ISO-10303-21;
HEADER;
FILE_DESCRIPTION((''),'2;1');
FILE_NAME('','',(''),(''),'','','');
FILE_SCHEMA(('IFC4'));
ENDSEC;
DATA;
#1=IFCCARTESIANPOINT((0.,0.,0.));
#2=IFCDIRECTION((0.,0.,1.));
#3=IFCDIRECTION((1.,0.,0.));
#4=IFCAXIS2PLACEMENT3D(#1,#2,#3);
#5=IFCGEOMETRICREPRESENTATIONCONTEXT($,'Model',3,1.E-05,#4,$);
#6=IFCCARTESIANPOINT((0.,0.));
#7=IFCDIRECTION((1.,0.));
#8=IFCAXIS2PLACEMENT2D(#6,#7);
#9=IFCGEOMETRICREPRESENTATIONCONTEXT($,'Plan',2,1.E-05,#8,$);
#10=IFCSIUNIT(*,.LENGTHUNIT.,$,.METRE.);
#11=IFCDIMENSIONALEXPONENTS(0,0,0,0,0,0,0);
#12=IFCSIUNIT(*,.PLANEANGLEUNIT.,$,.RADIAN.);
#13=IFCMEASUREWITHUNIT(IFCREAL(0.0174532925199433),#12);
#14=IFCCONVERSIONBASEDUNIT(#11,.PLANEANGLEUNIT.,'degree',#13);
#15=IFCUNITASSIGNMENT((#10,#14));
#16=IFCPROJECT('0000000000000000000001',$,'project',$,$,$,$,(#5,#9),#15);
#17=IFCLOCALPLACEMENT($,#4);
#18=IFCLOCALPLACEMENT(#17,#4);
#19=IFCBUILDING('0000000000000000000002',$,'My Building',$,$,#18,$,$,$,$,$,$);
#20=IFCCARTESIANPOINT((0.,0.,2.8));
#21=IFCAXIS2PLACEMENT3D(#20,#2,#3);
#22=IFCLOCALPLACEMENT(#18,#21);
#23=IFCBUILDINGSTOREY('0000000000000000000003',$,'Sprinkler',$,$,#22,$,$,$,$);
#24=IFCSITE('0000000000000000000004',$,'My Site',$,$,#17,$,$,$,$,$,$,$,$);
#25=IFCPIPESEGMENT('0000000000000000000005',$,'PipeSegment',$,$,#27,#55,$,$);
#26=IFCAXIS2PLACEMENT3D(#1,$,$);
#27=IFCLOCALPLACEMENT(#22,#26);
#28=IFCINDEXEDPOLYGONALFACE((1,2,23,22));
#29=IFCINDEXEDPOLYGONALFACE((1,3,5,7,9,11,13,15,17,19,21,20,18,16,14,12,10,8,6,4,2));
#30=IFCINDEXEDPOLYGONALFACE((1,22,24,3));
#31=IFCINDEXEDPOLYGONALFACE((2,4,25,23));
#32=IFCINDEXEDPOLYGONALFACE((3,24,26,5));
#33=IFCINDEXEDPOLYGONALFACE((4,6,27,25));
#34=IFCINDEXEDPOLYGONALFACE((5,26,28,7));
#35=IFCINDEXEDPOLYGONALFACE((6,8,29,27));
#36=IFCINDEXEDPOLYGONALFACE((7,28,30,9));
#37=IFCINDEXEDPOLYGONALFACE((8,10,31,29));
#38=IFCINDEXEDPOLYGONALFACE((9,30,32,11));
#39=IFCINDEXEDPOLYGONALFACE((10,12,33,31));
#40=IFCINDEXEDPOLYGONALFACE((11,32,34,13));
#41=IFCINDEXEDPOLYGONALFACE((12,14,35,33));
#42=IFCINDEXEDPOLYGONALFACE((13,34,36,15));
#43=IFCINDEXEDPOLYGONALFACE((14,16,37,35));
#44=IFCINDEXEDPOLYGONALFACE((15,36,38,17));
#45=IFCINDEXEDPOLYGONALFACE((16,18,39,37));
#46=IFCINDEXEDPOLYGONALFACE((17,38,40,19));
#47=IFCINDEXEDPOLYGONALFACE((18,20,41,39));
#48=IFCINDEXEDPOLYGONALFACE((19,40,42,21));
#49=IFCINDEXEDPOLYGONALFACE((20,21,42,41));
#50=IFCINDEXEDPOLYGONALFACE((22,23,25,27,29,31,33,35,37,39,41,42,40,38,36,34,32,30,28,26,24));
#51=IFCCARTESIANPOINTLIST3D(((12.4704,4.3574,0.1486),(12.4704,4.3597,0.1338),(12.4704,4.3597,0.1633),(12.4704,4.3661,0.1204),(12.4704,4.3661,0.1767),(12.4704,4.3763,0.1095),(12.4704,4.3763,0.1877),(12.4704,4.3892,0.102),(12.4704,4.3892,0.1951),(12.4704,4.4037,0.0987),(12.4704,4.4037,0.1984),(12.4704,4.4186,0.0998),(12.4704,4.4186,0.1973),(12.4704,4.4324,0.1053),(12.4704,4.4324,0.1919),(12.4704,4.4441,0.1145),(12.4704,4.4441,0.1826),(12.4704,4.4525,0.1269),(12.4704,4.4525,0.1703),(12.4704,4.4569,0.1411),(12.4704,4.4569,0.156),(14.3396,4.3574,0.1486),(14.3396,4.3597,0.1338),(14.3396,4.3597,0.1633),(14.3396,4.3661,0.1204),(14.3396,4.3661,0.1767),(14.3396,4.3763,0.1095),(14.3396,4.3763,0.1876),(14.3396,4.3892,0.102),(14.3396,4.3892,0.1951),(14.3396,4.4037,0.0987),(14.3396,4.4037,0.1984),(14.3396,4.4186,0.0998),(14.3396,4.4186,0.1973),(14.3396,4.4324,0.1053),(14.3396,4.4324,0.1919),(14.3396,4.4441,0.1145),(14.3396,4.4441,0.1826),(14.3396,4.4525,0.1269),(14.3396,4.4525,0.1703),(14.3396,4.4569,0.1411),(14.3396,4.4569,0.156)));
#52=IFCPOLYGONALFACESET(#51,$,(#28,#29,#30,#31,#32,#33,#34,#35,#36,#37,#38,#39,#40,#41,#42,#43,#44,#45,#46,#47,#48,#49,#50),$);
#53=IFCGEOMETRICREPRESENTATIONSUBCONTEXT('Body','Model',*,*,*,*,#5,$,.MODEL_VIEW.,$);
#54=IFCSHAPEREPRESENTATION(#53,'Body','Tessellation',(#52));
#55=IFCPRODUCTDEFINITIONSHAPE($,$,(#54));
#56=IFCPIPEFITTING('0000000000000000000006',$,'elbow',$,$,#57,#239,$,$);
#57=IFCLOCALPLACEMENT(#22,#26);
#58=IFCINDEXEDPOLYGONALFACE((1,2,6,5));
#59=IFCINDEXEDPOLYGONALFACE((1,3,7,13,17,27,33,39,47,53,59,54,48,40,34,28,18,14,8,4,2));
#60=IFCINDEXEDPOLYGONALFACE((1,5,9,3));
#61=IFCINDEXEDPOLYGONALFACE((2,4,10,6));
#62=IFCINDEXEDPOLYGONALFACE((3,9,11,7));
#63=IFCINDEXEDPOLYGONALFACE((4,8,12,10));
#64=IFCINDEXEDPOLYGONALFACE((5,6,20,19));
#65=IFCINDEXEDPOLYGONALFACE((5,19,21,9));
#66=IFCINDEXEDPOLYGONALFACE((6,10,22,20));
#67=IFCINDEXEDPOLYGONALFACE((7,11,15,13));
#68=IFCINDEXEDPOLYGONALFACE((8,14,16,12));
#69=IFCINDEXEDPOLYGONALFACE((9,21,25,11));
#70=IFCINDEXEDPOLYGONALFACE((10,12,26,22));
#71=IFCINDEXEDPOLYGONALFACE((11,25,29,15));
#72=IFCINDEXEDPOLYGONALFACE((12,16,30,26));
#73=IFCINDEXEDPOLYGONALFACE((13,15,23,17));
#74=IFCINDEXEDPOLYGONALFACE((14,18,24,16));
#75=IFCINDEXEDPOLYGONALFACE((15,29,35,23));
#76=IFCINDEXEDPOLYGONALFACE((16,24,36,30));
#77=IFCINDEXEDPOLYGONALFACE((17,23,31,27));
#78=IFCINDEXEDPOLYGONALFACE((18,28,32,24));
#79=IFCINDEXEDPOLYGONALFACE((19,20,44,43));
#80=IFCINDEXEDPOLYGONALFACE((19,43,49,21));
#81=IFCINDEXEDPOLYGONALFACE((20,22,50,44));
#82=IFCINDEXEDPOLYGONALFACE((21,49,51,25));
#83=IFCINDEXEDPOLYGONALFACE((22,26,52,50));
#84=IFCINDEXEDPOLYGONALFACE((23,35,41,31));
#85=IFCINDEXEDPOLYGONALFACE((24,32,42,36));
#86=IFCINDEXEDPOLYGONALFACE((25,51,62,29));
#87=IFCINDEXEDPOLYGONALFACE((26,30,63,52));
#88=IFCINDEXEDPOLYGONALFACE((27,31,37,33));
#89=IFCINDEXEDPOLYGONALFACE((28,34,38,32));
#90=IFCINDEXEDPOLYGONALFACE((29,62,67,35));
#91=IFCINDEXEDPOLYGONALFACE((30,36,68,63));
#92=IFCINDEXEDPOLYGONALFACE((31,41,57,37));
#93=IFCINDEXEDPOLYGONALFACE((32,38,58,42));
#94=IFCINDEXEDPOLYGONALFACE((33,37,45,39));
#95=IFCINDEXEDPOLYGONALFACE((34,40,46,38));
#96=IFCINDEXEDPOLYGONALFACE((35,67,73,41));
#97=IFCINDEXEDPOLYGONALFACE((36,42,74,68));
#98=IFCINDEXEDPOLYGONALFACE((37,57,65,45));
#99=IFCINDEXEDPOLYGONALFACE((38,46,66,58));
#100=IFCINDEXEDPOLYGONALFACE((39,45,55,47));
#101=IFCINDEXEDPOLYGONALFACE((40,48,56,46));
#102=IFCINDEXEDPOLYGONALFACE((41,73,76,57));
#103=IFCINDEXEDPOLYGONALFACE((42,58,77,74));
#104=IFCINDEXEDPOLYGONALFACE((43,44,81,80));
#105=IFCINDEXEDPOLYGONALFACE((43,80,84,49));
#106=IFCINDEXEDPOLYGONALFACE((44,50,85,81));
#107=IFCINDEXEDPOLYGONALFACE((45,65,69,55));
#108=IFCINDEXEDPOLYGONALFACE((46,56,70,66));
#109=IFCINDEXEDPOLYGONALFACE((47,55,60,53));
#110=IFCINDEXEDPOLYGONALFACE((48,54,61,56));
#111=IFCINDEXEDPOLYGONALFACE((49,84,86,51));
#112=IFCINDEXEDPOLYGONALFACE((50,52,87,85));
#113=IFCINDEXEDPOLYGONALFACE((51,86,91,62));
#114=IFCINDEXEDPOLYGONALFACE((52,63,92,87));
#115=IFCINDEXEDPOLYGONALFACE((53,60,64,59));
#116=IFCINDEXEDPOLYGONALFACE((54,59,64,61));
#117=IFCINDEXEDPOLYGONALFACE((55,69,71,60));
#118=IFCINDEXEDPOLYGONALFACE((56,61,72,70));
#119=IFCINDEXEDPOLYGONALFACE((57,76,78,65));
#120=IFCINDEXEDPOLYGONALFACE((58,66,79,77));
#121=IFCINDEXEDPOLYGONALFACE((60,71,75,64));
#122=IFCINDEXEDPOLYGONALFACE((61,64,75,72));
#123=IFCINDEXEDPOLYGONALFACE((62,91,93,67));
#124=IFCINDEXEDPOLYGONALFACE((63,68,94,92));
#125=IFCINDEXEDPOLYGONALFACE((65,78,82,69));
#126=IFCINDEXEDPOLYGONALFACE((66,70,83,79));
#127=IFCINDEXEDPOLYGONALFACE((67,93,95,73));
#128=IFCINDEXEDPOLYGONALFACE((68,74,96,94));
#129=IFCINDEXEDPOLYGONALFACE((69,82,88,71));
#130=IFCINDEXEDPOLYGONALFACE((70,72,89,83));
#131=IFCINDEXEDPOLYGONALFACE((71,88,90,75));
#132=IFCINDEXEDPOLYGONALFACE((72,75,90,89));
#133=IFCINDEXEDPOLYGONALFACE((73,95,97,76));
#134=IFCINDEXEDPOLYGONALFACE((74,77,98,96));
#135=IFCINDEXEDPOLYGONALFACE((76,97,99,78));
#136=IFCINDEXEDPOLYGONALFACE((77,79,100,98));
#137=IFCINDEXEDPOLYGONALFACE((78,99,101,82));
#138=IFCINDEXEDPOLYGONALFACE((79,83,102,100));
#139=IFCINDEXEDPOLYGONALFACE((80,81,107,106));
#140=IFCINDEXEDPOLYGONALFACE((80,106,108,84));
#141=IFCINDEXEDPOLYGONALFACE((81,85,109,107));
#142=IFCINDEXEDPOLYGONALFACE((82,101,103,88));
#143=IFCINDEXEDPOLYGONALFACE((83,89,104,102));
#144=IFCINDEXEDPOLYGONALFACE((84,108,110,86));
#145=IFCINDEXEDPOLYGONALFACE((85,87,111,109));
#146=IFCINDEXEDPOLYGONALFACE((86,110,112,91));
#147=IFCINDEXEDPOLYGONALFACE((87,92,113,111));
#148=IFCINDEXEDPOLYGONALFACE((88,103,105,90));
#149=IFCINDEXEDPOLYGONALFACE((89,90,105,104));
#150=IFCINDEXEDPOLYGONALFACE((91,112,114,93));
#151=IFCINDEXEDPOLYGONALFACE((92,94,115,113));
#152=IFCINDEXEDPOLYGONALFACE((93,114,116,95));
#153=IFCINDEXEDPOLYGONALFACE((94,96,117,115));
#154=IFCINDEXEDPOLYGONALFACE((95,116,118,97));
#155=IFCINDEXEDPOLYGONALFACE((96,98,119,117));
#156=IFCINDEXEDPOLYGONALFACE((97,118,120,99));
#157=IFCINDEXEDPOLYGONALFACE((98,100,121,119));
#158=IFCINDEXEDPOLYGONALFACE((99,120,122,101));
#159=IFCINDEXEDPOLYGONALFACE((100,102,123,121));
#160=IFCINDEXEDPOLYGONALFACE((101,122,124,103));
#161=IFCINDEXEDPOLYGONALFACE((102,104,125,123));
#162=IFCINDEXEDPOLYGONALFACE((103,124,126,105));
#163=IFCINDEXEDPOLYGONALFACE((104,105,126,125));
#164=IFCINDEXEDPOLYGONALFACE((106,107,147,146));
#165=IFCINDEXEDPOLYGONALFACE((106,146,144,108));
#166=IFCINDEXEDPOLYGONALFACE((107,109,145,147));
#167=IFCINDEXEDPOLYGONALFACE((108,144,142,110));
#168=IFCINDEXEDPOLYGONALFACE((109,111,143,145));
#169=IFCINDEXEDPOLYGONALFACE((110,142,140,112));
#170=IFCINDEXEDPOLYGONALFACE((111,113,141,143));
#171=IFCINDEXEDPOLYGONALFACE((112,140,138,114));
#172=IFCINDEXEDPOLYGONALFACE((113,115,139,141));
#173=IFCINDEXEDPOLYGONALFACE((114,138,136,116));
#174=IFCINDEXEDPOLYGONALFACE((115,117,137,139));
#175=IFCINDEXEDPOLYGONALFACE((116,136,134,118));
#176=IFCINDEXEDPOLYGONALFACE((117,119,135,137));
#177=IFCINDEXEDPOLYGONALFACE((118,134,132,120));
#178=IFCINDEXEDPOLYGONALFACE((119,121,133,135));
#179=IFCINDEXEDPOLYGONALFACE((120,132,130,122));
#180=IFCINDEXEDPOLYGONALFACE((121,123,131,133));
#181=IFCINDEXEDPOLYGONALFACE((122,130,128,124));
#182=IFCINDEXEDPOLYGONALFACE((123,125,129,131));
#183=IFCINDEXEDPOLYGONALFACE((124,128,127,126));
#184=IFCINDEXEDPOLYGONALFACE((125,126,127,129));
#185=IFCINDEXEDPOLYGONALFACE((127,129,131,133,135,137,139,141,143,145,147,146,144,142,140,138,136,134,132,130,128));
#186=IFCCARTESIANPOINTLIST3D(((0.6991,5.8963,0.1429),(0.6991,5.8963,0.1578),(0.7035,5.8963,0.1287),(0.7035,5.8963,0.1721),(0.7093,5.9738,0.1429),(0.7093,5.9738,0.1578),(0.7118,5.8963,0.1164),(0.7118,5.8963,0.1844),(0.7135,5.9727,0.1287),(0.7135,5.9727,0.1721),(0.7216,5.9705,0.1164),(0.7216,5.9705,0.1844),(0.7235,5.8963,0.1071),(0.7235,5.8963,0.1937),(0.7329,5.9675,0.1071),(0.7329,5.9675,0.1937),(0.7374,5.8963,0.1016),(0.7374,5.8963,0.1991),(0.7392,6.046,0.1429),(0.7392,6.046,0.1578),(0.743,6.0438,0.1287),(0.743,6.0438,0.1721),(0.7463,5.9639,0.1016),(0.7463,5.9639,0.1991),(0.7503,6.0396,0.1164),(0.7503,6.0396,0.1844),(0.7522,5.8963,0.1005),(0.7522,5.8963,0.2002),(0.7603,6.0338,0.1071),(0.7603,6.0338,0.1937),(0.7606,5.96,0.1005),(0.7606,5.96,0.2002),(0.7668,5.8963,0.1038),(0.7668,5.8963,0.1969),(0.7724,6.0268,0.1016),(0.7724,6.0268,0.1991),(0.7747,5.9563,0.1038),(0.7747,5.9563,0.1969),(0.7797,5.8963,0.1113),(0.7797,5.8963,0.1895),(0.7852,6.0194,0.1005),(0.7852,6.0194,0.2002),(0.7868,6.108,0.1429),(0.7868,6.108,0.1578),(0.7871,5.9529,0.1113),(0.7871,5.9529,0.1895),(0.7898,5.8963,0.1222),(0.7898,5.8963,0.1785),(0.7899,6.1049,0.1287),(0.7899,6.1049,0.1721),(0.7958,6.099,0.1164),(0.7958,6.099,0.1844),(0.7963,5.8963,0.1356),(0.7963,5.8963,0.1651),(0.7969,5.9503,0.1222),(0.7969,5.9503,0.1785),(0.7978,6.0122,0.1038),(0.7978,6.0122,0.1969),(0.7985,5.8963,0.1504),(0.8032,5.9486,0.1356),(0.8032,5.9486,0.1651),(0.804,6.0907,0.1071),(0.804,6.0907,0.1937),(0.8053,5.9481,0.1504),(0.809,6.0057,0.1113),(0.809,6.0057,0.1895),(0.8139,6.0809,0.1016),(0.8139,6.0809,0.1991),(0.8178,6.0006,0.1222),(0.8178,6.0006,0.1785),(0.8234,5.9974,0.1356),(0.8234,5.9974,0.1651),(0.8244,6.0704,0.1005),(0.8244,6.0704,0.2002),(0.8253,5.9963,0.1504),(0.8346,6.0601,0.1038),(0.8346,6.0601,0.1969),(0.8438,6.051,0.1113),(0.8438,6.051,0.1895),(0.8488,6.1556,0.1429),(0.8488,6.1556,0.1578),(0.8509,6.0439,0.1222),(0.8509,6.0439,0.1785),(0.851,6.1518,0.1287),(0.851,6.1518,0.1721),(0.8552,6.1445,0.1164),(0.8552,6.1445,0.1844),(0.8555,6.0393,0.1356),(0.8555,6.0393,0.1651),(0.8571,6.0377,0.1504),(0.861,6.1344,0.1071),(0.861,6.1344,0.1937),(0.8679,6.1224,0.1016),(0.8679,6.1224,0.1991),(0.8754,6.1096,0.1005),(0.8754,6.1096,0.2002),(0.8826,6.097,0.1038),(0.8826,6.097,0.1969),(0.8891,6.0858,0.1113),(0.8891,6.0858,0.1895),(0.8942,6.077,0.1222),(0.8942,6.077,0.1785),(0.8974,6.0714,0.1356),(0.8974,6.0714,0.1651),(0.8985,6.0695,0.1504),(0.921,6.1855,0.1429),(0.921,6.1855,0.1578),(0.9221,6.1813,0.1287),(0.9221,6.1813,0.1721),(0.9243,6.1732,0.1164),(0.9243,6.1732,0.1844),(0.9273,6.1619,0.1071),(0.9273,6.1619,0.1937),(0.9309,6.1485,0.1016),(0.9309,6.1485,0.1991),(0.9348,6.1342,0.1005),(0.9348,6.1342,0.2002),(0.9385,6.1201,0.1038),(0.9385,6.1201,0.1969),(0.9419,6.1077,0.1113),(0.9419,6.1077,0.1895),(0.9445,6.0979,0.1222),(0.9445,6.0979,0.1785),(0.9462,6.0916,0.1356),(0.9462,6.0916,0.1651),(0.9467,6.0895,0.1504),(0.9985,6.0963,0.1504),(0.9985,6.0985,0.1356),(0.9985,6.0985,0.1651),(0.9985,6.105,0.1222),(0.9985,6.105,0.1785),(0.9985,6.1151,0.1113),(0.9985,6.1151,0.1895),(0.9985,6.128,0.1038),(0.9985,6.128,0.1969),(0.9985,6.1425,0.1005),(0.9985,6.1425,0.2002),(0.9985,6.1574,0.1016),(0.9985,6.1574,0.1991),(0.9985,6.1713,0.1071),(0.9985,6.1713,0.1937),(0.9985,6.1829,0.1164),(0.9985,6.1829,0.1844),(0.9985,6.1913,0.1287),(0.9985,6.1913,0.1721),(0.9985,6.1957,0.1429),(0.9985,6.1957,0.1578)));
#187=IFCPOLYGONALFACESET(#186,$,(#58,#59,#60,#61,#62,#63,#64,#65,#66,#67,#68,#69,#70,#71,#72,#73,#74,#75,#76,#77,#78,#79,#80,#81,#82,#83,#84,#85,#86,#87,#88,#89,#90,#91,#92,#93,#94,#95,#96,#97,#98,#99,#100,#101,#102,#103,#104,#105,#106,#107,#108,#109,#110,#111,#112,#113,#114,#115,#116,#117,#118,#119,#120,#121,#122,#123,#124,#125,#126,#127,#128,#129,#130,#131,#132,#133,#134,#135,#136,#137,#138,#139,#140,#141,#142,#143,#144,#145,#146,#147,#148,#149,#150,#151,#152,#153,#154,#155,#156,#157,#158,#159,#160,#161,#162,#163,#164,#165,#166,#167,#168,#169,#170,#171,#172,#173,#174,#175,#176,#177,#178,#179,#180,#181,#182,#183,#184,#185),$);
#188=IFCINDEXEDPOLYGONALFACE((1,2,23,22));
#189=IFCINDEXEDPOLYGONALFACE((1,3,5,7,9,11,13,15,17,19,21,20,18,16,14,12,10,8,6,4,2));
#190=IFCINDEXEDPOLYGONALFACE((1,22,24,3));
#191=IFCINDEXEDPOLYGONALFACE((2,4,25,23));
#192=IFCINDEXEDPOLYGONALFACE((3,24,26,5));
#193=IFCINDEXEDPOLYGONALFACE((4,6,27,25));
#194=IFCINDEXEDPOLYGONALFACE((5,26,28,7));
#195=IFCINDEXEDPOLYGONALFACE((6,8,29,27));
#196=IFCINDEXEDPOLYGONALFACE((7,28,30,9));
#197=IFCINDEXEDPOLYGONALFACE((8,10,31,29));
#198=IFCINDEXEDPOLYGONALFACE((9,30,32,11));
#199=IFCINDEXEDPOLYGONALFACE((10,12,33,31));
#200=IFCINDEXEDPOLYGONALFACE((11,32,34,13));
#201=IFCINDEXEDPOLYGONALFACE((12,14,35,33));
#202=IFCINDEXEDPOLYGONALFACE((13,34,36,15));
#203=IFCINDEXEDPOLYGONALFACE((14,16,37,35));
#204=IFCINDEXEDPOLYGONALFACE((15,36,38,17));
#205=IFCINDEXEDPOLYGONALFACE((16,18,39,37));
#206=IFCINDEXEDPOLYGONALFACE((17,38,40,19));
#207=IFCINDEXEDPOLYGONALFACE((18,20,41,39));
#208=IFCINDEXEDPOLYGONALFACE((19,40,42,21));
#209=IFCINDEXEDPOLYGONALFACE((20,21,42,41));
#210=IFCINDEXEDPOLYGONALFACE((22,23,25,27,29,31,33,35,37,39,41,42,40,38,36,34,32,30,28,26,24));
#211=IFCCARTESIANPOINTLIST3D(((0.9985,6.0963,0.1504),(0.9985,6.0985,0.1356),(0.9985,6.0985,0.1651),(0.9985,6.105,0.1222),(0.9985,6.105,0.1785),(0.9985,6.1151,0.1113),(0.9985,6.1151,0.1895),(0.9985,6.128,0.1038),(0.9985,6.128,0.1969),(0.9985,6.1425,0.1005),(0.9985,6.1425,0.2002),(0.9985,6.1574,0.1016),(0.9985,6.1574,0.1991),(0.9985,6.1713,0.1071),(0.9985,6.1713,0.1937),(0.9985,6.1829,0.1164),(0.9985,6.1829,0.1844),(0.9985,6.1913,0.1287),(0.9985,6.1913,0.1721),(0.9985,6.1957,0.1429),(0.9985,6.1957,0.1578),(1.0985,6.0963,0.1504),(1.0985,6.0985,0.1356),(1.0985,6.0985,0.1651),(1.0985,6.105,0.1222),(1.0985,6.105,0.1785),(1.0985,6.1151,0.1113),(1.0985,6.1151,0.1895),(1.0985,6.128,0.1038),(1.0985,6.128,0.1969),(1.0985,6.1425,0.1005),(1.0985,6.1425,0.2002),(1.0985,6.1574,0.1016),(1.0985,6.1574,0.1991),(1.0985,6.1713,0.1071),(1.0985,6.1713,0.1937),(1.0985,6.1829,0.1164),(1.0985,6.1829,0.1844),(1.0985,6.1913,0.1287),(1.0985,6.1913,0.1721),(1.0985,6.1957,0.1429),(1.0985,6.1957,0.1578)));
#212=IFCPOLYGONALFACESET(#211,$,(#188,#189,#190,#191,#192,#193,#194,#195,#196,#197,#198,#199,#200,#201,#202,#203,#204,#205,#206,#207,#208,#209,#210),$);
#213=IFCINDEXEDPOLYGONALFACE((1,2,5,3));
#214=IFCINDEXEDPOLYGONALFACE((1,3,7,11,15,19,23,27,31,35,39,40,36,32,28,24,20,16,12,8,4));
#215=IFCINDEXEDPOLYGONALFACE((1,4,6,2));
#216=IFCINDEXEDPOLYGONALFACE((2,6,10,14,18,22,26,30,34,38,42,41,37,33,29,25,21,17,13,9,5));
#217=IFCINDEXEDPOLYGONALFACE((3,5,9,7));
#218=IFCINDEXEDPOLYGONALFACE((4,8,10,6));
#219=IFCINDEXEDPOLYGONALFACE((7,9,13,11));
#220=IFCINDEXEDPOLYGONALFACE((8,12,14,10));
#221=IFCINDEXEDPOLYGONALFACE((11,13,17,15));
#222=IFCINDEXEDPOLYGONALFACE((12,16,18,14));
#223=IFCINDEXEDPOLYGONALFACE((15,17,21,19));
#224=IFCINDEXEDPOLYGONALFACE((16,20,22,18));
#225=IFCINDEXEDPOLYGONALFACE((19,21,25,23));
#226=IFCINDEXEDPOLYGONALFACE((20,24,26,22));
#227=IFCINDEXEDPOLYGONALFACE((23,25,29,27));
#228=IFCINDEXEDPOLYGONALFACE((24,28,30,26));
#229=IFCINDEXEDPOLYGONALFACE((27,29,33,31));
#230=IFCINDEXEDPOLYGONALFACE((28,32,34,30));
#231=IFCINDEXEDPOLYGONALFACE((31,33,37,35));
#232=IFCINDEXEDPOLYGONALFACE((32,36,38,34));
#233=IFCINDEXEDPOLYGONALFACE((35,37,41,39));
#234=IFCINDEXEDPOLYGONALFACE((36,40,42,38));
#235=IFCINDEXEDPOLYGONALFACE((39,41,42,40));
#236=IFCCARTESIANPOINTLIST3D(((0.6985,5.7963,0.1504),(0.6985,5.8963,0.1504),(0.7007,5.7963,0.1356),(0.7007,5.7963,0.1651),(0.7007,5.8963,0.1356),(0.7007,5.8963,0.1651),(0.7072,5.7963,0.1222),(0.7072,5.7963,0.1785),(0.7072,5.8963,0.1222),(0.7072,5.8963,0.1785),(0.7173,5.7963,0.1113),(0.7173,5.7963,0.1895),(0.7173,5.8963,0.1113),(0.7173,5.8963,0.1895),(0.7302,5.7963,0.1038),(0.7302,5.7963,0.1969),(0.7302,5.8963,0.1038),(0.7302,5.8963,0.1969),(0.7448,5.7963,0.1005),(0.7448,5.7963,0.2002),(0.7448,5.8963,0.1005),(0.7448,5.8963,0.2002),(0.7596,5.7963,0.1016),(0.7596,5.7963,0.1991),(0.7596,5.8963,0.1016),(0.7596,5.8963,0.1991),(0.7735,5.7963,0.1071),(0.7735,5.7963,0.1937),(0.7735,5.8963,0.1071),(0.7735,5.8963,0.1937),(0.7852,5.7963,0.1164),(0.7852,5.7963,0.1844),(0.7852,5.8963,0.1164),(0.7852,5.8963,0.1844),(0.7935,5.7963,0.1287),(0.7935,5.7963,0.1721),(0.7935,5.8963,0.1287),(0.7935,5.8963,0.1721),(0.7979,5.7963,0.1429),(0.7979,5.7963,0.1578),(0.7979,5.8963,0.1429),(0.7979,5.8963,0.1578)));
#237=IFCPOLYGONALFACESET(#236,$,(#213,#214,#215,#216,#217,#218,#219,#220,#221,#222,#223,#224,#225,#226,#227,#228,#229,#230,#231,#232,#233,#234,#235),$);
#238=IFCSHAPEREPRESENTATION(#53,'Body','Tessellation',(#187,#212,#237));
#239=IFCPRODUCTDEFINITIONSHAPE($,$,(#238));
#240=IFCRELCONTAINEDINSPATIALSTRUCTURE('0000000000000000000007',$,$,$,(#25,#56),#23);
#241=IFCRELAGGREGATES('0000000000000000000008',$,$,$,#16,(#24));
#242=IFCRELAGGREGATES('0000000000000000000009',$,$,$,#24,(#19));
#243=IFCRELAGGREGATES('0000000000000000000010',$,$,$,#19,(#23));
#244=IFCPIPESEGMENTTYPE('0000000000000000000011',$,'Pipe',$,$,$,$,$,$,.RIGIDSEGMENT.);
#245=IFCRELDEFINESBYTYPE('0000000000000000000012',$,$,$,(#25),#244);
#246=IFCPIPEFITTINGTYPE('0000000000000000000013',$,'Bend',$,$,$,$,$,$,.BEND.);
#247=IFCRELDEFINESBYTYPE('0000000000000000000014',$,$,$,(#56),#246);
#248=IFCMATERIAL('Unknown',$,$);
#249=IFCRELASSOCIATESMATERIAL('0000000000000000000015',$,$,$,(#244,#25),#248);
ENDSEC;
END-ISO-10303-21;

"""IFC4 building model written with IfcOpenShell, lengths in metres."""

from ifc_helpers import new_model, entity, si_unit, converted_unit, frame, origin_with_axes, origin_2d_with_axis, place, context, subcontext, project, spatial, circle, extrude, source, transform, mapped, material, material_profile, profile_set, profile_usage, type_object, type_shapes, element, save


model = new_model("IFC4")

# Units and contexts
model_context = context("Model", 3, precision=1e-05, world=origin_with_axes())
plan_context = context("Plan", 2, precision=1e-05, world=origin_2d_with_axis())
body_context = subcontext(model_context, "Body", "Model", "MODEL_VIEW")
ifc_project = project(units=[si_unit("LENGTHUNIT", "METRE"), converted_unit("PLANEANGLEUNIT", "degree", entity("IfcReal", 0.0174532925199433), si_unit("PLANEANGLEUNIT", "RADIAN"), dimensions=[0, 0, 0, 0, 0, 0, 0])], contexts=[model_context, plan_context])

# Site, building, storey
site_placement = place(None, origin_with_axes())
site = spatial("IfcSite", under=ifc_project, at=site_placement, Name="My Site")
building_placement = place(site_placement, origin_with_axes())
building = spatial("IfcBuilding", under=site, at=building_placement, Name="My Building")
storey_placement = place(building_placement, frame((0.0, 0.0, 2.8), z_axis=(0.0, 0.0, 1.0), x_axis=(1.0, 0.0, 0.0)))
storey = spatial("IfcBuildingStorey", under=building, at=storey_placement, Name="Sprinkler")

# Pipe segment
ifc_material = material(Name="Unknown")
ifc_material_profile_1 = material_profile(ifc_material, circle(Radius=0.05))
ifc_profile_set_1 = profile_set([ifc_material_profile_1])
pipe_segment_type = type_object("IfcPipeSegmentType", Name="Pipe", PredefinedType="RIGIDSEGMENT", material=ifc_profile_set_1)
ifc_profile_usage_1 = profile_usage(ifc_profile_set_1, cardinal=8)
pipe_segment_1_placement = place(storey_placement, frame((14.3396, 4.4074, 0.1986), z_axis=(-1.0, 0.0, 0.0), x_axis=(0.0, -1.0, 0.0)))
element("IfcPipeSegment", 1, at=pipe_segment_1_placement, inside=storey, type_object=pipe_segment_type, material=ifc_profile_usage_1, Name="PipeSegment", context=body_context, shape_type="SweptSolid", body=[
    extrude(circle(Radius=0.05), frame((0.0, -0.05, 0.0), z_axis=(0.0, 0.0, 1.0), x_axis=(1.0, 0.0, 0.0)), (0.0, 0.0, 1.0), 1.8692),
])

# Pipe fitting
pipe_fitting_type_1 = type_object("IfcPipeFittingType", Name="Bend", PredefinedType="BEND")
shared_shape_1 = source(origin_with_axes(), body_context, "Body", "SolidModel", [
    entity("IfcSweptDiskSolid", entity("IfcIndexedPolyCurve", entity("IfcCartesianPointList3D", [[0.0, 0.0, 0.1], [0.0732, 0.0, 0.2768], [0.25, 0.0, 0.35]]), [entity("IfcArcIndex", [1, 2, 3])]), 0.05),
    extrude(circle(Radius=0.05), origin_with_axes(), (0.0, 0.0, 1.0), 0.1),
    extrude(circle(Radius=0.05), frame((0.25, 0.0, 0.35), z_axis=(1.0, 0.0, 0.000001), x_axis=(-0.000001, 0.0, 1.0)), (0.0, 0.0, 1.0), 0.1),
])
type_shapes(pipe_fitting_type_1, [shared_shape_1])
for number, where, z_axis, x_axis, name in (
    (2, (1.0985, 6.1463, 0.1504), (-1.0, -0.000001, 0.0), (0.000001, -1.0, 0.0), "elbow"),
):
    element("IfcPipeFitting", number, at=place(storey_placement, frame(where, z_axis=z_axis, x_axis=x_axis)), inside=storey, type_object=pipe_fitting_type_1, Name=name, context=body_context, shape_type="MappedRepresentation", body=[
        mapped(shared_shape_1, transform((0.0, 0.0, 0.0), x_axis=(1.0, 0.0, 0.0), y_axis=(0.0, 1.0, 0.0), z_axis=(0.0, 0.0, 1.0), scale=1.0)),
    ])

save(model, "model.ifc")
